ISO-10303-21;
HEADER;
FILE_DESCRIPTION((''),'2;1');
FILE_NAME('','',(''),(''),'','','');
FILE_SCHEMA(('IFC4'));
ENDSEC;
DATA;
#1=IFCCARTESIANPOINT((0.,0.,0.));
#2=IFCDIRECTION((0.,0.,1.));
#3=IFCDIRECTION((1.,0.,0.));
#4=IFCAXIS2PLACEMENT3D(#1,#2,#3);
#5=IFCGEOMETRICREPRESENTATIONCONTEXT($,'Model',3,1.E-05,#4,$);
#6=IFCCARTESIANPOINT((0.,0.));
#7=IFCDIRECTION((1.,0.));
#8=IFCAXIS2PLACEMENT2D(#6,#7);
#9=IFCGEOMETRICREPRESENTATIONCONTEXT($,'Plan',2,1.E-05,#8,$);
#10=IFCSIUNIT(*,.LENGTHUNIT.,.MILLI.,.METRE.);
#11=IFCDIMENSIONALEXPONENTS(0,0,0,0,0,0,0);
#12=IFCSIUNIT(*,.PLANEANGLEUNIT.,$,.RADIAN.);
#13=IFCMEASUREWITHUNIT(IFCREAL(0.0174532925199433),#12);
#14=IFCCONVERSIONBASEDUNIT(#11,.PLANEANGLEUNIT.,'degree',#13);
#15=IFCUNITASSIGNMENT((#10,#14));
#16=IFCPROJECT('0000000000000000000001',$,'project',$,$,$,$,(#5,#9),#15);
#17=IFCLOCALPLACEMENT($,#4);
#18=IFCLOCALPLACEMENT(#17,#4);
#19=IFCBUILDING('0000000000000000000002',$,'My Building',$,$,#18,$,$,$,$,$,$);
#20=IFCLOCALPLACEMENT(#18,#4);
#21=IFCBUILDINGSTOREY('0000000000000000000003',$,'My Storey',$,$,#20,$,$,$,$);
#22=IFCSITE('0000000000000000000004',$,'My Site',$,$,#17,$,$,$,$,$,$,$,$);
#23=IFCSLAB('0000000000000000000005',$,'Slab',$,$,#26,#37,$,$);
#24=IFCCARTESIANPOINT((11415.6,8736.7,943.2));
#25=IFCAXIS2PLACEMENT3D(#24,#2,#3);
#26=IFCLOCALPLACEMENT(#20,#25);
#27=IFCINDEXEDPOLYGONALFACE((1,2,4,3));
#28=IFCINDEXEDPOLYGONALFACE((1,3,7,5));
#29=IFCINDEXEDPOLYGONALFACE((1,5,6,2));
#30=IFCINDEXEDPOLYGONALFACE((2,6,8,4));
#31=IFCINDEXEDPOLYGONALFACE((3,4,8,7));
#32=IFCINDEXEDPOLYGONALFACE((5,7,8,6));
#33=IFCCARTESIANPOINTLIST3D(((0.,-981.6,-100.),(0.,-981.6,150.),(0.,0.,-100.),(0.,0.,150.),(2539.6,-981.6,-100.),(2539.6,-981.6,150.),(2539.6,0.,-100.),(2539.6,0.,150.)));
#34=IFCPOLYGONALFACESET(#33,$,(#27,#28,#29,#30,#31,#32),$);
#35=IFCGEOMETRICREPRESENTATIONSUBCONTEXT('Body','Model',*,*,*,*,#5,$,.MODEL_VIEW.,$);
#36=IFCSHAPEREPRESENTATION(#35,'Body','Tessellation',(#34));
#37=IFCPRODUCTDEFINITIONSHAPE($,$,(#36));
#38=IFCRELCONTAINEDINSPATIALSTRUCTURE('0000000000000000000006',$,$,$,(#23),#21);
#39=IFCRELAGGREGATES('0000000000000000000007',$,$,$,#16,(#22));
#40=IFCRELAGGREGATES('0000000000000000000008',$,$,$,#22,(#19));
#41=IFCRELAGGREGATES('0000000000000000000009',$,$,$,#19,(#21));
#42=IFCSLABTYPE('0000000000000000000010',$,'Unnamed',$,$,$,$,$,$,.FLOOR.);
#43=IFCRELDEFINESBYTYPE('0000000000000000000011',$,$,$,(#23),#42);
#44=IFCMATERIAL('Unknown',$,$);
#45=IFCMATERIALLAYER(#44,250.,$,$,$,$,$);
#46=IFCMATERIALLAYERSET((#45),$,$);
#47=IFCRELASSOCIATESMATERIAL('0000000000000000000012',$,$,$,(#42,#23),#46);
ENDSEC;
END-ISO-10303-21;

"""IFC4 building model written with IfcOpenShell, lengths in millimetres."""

from ifc_helpers import new_model, entity, si_unit, converted_unit, frame, origin_with_axes, origin_2d_with_axis, place, context, subcontext, project, spatial, indexed_curve, outline, extrude, material, layer, layer_set, layer_usage, type_object, element, save


model = new_model("IFC4")

# Units and contexts
model_context = context("Model", 3, precision=1e-05, world=origin_with_axes())
plan_context = context("Plan", 2, precision=1e-05, world=origin_2d_with_axis())
body_context = subcontext(model_context, "Body", "Model", "MODEL_VIEW")
ifc_project = project(units=[si_unit("LENGTHUNIT", "METRE", prefix="MILLI"), converted_unit("PLANEANGLEUNIT", "degree", entity("IfcReal", 0.0174532925199433), si_unit("PLANEANGLEUNIT", "RADIAN"), dimensions=[0, 0, 0, 0, 0, 0, 0])], contexts=[model_context, plan_context])

# Site, building, storey
site_placement = place(None, origin_with_axes())
site = spatial("IfcSite", under=ifc_project, at=site_placement, Name="My Site")
building_placement = place(site_placement, origin_with_axes())
building = spatial("IfcBuilding", under=site, at=building_placement, Name="My Building")
storey_placement = place(building_placement, origin_with_axes())
storey = spatial("IfcBuildingStorey", under=building, at=storey_placement, Name="My Storey")

# Shared definitions
ifc_material = material(Name="Unknown")

# Slab
ifc_layer_1 = layer(ifc_material, 250.0)
ifc_layer_set_1 = layer_set([ifc_layer_1])
ifc_layer_usage_1 = layer_usage(ifc_layer_set_1, "AXIS3", "POSITIVE", -100.0)
slab_type = type_object("IfcSlabType", Name="Unnamed", PredefinedType="FLOOR", material=ifc_layer_set_1)
slab_placement = place(storey_placement, frame((11415.6, 8736.7, 943.2), z_axis=(0.0, 0.0, 1.0), x_axis=(1.0, 0.0, 0.0)))
element("IfcSlab", 1, at=slab_placement, inside=storey, type_object=slab_type, material=ifc_layer_usage_1, Name="Slab", context=body_context, shape_type="SweptSolid", body=[
    extrude(outline(indexed_curve([(0.0, 0.0), (2539.6, 0.0), (2539.6, -981.6), (0.0, -981.6), (0.0, 0.0)])), frame((0.0, 0.0, -100.0), z_axis=(0.0, 0.0, 1.0), x_axis=(1.0, 0.0, 0.0)), (0.0, 0.0, 1.0), 250.0),
])

save(model, "model.ifc")
